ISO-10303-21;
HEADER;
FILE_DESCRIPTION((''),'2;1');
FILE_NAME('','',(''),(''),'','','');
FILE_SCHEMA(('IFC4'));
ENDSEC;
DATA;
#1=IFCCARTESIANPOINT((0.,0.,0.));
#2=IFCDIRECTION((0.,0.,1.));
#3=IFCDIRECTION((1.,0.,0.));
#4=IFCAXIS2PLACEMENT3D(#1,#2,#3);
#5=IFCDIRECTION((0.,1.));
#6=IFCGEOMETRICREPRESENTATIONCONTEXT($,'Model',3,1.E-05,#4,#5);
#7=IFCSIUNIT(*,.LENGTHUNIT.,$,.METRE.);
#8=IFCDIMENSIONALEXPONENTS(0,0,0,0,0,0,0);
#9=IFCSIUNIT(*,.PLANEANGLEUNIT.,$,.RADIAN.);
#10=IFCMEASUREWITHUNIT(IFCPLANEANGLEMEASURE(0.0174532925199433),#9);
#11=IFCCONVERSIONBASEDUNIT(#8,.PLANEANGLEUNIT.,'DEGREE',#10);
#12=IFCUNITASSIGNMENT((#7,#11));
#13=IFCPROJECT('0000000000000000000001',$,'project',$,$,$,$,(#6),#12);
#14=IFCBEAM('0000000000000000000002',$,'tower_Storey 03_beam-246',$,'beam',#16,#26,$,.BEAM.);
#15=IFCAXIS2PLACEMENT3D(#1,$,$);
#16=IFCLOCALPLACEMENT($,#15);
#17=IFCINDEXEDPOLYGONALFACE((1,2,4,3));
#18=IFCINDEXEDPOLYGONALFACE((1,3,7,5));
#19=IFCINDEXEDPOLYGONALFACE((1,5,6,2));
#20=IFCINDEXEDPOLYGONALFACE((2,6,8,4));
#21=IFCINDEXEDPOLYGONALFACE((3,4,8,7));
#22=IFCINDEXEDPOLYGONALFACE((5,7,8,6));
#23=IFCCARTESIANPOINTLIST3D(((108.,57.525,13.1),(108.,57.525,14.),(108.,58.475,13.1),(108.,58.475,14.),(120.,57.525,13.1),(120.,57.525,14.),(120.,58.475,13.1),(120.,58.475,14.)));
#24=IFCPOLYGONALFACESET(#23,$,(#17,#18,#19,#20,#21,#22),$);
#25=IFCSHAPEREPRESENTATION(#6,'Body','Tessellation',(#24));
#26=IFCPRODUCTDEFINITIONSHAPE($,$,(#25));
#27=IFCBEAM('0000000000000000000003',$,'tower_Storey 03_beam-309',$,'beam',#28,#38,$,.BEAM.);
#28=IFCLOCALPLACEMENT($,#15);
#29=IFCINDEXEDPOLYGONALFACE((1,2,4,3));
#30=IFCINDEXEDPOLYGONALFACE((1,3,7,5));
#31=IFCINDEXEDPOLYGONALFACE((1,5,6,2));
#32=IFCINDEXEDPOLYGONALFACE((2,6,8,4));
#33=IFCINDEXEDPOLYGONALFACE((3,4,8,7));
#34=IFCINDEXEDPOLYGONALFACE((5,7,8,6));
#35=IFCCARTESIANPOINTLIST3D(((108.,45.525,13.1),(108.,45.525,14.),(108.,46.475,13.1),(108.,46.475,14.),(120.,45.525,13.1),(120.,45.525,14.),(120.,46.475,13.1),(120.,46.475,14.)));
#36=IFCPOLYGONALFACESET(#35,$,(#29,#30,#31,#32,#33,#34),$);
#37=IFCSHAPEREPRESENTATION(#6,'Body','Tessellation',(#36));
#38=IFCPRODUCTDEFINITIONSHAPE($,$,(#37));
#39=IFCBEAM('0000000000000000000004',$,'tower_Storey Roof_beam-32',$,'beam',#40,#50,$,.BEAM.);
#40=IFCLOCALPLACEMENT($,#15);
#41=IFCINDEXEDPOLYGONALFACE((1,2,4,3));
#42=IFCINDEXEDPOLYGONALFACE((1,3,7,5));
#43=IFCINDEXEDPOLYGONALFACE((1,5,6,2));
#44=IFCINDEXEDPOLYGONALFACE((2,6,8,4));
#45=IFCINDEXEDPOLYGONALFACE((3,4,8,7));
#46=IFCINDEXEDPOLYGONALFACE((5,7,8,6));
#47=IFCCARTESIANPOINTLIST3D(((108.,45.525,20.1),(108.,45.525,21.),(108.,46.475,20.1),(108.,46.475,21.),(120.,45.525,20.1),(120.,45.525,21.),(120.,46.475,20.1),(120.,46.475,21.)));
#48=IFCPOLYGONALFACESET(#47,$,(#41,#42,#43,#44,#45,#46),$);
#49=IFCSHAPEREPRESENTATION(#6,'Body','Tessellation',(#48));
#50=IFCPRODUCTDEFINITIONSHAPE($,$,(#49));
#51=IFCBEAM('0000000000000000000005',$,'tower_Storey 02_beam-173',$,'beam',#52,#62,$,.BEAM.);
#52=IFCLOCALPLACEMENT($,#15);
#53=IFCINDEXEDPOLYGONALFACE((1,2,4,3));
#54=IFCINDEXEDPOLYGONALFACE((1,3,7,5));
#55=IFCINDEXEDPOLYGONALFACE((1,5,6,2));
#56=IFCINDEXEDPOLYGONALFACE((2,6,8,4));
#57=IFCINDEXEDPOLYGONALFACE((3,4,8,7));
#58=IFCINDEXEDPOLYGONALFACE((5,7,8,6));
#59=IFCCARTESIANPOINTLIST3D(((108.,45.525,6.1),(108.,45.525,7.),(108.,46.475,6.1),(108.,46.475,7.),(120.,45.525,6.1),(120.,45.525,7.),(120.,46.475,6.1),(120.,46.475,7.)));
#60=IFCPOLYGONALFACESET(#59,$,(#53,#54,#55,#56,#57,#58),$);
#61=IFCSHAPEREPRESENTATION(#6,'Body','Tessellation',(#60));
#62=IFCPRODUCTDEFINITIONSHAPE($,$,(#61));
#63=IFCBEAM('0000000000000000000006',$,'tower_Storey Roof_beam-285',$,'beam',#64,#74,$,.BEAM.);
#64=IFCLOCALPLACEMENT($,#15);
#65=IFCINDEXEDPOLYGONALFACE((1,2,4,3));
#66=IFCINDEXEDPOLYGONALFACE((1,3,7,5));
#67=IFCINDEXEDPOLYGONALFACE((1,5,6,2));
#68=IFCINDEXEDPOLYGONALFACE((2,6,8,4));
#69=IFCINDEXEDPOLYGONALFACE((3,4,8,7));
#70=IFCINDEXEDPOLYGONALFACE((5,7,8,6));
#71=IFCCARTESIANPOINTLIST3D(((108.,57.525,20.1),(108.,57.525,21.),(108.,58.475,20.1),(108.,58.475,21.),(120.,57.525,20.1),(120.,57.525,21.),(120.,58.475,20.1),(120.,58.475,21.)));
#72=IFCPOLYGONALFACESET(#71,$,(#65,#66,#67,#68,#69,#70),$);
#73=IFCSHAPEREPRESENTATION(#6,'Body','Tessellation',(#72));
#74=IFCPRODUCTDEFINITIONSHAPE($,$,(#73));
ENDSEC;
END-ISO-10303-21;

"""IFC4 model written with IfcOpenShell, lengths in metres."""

from ifc_helpers import new_model, entity, si_unit, converted_unit, direction, frame, origin_with_axes, place, context, project, polyline, outline, extrude, element, save


model = new_model("IFC4")

# Units and contexts
model_context = context("Model", 3, precision=1e-05, world=origin_with_axes(), true_north=direction((0.0, 1.0)))
ifc_project = project(units=[si_unit("LENGTHUNIT", "METRE"), converted_unit("PLANEANGLEUNIT", "DEGREE", entity("IfcPlaneAngleMeasure", 0.0174532925199433), si_unit("PLANEANGLEUNIT", "RADIAN"), dimensions=[0, 0, 0, 0, 0, 0, 0])], contexts=[model_context])

# Shared definitions
placement_1 = place(None, origin_with_axes())
placement_2 = place(placement_1, frame((0.0, 0.0, 14.0), z_axis=(0.0, 0.0, 1.0), x_axis=(1.0, 0.0, 0.0)))
placement_3 = place(placement_1, frame((0.0, 0.0, 7.0), z_axis=(0.0, 0.0, 1.0), x_axis=(1.0, 0.0, 0.0)))

# Beams
placement_4 = place(placement_1, frame((0.0, 0.0, 21.0), z_axis=(0.0, 0.0, 1.0), x_axis=(1.0, 0.0, 0.0)))
for number, where, z_axis, x_axis, name in (
    (1, (108.0, 58.0, -0.45), (1.0, 0.0, 0.0), (0.0, 1.0, 0.0), "tower_Storey 03_beam-246"),
    (2, (108.0, 46.0, -0.45), (1.0, 0.0, 0.0), (0.0, 1.0, 0.0), "tower_Storey 03_beam-309"),
):
    element("IfcBeam", number, at=place(placement_2, frame(where, z_axis=z_axis, x_axis=x_axis)), Name=name, ObjectType="beam", PredefinedType="BEAM", context=model_context, body=[
        extrude(outline(polyline([(0.475, 0.45, 0.0), (-0.475, 0.45, 0.0), (-0.475, -0.45, 0.0), (0.475, -0.45, 0.0), (0.475, 0.45, 0.0)])), origin_with_axes(), (0.0, 0.0, 1.0), 12.0),
    ])
beam_1_placement = place(placement_4, frame((108.0, 46.0, -0.45), z_axis=(1.0, 0.0, 0.0), x_axis=(0.0, 1.0, 0.0)))
element("IfcBeam", 3, at=beam_1_placement, Name="tower_Storey Roof_beam-32", ObjectType="beam", PredefinedType="BEAM", context=model_context, body=[
    extrude(outline(polyline([(0.475, 0.45, 0.0), (-0.475, 0.45, 0.0), (-0.475, -0.45, 0.0), (0.475, -0.45, 0.0), (0.475, 0.45, 0.0)])), origin_with_axes(), (0.0, 0.0, 1.0), 12.0),
])
beam_2_placement = place(placement_3, frame((108.0, 46.0, -0.45), z_axis=(1.0, 0.0, 0.0), x_axis=(0.0, 1.0, 0.0)))
element("IfcBeam", 4, at=beam_2_placement, Name="tower_Storey 02_beam-173", ObjectType="beam", PredefinedType="BEAM", context=model_context, body=[
    extrude(outline(polyline([(0.475, 0.45, 0.0), (-0.475, 0.45, 0.0), (-0.475, -0.45, 0.0), (0.475, -0.45, 0.0), (0.475, 0.45, 0.0)])), origin_with_axes(), (0.0, 0.0, 1.0), 12.0),
])
beam_3_placement = place(placement_4, frame((108.0, 58.0, -0.45), z_axis=(1.0, 0.0, 0.0), x_axis=(0.0, 1.0, 0.0)))
element("IfcBeam", 5, at=beam_3_placement, Name="tower_Storey Roof_beam-285", ObjectType="beam", PredefinedType="BEAM", context=model_context, body=[
    extrude(outline(polyline([(0.475, 0.45, 0.0), (-0.475, 0.45, 0.0), (-0.475, -0.45, 0.0), (0.475, -0.45, 0.0), (0.475, 0.45, 0.0)])), origin_with_axes(), (0.0, 0.0, 1.0), 12.0),
])

save(model, "model.ifc")
